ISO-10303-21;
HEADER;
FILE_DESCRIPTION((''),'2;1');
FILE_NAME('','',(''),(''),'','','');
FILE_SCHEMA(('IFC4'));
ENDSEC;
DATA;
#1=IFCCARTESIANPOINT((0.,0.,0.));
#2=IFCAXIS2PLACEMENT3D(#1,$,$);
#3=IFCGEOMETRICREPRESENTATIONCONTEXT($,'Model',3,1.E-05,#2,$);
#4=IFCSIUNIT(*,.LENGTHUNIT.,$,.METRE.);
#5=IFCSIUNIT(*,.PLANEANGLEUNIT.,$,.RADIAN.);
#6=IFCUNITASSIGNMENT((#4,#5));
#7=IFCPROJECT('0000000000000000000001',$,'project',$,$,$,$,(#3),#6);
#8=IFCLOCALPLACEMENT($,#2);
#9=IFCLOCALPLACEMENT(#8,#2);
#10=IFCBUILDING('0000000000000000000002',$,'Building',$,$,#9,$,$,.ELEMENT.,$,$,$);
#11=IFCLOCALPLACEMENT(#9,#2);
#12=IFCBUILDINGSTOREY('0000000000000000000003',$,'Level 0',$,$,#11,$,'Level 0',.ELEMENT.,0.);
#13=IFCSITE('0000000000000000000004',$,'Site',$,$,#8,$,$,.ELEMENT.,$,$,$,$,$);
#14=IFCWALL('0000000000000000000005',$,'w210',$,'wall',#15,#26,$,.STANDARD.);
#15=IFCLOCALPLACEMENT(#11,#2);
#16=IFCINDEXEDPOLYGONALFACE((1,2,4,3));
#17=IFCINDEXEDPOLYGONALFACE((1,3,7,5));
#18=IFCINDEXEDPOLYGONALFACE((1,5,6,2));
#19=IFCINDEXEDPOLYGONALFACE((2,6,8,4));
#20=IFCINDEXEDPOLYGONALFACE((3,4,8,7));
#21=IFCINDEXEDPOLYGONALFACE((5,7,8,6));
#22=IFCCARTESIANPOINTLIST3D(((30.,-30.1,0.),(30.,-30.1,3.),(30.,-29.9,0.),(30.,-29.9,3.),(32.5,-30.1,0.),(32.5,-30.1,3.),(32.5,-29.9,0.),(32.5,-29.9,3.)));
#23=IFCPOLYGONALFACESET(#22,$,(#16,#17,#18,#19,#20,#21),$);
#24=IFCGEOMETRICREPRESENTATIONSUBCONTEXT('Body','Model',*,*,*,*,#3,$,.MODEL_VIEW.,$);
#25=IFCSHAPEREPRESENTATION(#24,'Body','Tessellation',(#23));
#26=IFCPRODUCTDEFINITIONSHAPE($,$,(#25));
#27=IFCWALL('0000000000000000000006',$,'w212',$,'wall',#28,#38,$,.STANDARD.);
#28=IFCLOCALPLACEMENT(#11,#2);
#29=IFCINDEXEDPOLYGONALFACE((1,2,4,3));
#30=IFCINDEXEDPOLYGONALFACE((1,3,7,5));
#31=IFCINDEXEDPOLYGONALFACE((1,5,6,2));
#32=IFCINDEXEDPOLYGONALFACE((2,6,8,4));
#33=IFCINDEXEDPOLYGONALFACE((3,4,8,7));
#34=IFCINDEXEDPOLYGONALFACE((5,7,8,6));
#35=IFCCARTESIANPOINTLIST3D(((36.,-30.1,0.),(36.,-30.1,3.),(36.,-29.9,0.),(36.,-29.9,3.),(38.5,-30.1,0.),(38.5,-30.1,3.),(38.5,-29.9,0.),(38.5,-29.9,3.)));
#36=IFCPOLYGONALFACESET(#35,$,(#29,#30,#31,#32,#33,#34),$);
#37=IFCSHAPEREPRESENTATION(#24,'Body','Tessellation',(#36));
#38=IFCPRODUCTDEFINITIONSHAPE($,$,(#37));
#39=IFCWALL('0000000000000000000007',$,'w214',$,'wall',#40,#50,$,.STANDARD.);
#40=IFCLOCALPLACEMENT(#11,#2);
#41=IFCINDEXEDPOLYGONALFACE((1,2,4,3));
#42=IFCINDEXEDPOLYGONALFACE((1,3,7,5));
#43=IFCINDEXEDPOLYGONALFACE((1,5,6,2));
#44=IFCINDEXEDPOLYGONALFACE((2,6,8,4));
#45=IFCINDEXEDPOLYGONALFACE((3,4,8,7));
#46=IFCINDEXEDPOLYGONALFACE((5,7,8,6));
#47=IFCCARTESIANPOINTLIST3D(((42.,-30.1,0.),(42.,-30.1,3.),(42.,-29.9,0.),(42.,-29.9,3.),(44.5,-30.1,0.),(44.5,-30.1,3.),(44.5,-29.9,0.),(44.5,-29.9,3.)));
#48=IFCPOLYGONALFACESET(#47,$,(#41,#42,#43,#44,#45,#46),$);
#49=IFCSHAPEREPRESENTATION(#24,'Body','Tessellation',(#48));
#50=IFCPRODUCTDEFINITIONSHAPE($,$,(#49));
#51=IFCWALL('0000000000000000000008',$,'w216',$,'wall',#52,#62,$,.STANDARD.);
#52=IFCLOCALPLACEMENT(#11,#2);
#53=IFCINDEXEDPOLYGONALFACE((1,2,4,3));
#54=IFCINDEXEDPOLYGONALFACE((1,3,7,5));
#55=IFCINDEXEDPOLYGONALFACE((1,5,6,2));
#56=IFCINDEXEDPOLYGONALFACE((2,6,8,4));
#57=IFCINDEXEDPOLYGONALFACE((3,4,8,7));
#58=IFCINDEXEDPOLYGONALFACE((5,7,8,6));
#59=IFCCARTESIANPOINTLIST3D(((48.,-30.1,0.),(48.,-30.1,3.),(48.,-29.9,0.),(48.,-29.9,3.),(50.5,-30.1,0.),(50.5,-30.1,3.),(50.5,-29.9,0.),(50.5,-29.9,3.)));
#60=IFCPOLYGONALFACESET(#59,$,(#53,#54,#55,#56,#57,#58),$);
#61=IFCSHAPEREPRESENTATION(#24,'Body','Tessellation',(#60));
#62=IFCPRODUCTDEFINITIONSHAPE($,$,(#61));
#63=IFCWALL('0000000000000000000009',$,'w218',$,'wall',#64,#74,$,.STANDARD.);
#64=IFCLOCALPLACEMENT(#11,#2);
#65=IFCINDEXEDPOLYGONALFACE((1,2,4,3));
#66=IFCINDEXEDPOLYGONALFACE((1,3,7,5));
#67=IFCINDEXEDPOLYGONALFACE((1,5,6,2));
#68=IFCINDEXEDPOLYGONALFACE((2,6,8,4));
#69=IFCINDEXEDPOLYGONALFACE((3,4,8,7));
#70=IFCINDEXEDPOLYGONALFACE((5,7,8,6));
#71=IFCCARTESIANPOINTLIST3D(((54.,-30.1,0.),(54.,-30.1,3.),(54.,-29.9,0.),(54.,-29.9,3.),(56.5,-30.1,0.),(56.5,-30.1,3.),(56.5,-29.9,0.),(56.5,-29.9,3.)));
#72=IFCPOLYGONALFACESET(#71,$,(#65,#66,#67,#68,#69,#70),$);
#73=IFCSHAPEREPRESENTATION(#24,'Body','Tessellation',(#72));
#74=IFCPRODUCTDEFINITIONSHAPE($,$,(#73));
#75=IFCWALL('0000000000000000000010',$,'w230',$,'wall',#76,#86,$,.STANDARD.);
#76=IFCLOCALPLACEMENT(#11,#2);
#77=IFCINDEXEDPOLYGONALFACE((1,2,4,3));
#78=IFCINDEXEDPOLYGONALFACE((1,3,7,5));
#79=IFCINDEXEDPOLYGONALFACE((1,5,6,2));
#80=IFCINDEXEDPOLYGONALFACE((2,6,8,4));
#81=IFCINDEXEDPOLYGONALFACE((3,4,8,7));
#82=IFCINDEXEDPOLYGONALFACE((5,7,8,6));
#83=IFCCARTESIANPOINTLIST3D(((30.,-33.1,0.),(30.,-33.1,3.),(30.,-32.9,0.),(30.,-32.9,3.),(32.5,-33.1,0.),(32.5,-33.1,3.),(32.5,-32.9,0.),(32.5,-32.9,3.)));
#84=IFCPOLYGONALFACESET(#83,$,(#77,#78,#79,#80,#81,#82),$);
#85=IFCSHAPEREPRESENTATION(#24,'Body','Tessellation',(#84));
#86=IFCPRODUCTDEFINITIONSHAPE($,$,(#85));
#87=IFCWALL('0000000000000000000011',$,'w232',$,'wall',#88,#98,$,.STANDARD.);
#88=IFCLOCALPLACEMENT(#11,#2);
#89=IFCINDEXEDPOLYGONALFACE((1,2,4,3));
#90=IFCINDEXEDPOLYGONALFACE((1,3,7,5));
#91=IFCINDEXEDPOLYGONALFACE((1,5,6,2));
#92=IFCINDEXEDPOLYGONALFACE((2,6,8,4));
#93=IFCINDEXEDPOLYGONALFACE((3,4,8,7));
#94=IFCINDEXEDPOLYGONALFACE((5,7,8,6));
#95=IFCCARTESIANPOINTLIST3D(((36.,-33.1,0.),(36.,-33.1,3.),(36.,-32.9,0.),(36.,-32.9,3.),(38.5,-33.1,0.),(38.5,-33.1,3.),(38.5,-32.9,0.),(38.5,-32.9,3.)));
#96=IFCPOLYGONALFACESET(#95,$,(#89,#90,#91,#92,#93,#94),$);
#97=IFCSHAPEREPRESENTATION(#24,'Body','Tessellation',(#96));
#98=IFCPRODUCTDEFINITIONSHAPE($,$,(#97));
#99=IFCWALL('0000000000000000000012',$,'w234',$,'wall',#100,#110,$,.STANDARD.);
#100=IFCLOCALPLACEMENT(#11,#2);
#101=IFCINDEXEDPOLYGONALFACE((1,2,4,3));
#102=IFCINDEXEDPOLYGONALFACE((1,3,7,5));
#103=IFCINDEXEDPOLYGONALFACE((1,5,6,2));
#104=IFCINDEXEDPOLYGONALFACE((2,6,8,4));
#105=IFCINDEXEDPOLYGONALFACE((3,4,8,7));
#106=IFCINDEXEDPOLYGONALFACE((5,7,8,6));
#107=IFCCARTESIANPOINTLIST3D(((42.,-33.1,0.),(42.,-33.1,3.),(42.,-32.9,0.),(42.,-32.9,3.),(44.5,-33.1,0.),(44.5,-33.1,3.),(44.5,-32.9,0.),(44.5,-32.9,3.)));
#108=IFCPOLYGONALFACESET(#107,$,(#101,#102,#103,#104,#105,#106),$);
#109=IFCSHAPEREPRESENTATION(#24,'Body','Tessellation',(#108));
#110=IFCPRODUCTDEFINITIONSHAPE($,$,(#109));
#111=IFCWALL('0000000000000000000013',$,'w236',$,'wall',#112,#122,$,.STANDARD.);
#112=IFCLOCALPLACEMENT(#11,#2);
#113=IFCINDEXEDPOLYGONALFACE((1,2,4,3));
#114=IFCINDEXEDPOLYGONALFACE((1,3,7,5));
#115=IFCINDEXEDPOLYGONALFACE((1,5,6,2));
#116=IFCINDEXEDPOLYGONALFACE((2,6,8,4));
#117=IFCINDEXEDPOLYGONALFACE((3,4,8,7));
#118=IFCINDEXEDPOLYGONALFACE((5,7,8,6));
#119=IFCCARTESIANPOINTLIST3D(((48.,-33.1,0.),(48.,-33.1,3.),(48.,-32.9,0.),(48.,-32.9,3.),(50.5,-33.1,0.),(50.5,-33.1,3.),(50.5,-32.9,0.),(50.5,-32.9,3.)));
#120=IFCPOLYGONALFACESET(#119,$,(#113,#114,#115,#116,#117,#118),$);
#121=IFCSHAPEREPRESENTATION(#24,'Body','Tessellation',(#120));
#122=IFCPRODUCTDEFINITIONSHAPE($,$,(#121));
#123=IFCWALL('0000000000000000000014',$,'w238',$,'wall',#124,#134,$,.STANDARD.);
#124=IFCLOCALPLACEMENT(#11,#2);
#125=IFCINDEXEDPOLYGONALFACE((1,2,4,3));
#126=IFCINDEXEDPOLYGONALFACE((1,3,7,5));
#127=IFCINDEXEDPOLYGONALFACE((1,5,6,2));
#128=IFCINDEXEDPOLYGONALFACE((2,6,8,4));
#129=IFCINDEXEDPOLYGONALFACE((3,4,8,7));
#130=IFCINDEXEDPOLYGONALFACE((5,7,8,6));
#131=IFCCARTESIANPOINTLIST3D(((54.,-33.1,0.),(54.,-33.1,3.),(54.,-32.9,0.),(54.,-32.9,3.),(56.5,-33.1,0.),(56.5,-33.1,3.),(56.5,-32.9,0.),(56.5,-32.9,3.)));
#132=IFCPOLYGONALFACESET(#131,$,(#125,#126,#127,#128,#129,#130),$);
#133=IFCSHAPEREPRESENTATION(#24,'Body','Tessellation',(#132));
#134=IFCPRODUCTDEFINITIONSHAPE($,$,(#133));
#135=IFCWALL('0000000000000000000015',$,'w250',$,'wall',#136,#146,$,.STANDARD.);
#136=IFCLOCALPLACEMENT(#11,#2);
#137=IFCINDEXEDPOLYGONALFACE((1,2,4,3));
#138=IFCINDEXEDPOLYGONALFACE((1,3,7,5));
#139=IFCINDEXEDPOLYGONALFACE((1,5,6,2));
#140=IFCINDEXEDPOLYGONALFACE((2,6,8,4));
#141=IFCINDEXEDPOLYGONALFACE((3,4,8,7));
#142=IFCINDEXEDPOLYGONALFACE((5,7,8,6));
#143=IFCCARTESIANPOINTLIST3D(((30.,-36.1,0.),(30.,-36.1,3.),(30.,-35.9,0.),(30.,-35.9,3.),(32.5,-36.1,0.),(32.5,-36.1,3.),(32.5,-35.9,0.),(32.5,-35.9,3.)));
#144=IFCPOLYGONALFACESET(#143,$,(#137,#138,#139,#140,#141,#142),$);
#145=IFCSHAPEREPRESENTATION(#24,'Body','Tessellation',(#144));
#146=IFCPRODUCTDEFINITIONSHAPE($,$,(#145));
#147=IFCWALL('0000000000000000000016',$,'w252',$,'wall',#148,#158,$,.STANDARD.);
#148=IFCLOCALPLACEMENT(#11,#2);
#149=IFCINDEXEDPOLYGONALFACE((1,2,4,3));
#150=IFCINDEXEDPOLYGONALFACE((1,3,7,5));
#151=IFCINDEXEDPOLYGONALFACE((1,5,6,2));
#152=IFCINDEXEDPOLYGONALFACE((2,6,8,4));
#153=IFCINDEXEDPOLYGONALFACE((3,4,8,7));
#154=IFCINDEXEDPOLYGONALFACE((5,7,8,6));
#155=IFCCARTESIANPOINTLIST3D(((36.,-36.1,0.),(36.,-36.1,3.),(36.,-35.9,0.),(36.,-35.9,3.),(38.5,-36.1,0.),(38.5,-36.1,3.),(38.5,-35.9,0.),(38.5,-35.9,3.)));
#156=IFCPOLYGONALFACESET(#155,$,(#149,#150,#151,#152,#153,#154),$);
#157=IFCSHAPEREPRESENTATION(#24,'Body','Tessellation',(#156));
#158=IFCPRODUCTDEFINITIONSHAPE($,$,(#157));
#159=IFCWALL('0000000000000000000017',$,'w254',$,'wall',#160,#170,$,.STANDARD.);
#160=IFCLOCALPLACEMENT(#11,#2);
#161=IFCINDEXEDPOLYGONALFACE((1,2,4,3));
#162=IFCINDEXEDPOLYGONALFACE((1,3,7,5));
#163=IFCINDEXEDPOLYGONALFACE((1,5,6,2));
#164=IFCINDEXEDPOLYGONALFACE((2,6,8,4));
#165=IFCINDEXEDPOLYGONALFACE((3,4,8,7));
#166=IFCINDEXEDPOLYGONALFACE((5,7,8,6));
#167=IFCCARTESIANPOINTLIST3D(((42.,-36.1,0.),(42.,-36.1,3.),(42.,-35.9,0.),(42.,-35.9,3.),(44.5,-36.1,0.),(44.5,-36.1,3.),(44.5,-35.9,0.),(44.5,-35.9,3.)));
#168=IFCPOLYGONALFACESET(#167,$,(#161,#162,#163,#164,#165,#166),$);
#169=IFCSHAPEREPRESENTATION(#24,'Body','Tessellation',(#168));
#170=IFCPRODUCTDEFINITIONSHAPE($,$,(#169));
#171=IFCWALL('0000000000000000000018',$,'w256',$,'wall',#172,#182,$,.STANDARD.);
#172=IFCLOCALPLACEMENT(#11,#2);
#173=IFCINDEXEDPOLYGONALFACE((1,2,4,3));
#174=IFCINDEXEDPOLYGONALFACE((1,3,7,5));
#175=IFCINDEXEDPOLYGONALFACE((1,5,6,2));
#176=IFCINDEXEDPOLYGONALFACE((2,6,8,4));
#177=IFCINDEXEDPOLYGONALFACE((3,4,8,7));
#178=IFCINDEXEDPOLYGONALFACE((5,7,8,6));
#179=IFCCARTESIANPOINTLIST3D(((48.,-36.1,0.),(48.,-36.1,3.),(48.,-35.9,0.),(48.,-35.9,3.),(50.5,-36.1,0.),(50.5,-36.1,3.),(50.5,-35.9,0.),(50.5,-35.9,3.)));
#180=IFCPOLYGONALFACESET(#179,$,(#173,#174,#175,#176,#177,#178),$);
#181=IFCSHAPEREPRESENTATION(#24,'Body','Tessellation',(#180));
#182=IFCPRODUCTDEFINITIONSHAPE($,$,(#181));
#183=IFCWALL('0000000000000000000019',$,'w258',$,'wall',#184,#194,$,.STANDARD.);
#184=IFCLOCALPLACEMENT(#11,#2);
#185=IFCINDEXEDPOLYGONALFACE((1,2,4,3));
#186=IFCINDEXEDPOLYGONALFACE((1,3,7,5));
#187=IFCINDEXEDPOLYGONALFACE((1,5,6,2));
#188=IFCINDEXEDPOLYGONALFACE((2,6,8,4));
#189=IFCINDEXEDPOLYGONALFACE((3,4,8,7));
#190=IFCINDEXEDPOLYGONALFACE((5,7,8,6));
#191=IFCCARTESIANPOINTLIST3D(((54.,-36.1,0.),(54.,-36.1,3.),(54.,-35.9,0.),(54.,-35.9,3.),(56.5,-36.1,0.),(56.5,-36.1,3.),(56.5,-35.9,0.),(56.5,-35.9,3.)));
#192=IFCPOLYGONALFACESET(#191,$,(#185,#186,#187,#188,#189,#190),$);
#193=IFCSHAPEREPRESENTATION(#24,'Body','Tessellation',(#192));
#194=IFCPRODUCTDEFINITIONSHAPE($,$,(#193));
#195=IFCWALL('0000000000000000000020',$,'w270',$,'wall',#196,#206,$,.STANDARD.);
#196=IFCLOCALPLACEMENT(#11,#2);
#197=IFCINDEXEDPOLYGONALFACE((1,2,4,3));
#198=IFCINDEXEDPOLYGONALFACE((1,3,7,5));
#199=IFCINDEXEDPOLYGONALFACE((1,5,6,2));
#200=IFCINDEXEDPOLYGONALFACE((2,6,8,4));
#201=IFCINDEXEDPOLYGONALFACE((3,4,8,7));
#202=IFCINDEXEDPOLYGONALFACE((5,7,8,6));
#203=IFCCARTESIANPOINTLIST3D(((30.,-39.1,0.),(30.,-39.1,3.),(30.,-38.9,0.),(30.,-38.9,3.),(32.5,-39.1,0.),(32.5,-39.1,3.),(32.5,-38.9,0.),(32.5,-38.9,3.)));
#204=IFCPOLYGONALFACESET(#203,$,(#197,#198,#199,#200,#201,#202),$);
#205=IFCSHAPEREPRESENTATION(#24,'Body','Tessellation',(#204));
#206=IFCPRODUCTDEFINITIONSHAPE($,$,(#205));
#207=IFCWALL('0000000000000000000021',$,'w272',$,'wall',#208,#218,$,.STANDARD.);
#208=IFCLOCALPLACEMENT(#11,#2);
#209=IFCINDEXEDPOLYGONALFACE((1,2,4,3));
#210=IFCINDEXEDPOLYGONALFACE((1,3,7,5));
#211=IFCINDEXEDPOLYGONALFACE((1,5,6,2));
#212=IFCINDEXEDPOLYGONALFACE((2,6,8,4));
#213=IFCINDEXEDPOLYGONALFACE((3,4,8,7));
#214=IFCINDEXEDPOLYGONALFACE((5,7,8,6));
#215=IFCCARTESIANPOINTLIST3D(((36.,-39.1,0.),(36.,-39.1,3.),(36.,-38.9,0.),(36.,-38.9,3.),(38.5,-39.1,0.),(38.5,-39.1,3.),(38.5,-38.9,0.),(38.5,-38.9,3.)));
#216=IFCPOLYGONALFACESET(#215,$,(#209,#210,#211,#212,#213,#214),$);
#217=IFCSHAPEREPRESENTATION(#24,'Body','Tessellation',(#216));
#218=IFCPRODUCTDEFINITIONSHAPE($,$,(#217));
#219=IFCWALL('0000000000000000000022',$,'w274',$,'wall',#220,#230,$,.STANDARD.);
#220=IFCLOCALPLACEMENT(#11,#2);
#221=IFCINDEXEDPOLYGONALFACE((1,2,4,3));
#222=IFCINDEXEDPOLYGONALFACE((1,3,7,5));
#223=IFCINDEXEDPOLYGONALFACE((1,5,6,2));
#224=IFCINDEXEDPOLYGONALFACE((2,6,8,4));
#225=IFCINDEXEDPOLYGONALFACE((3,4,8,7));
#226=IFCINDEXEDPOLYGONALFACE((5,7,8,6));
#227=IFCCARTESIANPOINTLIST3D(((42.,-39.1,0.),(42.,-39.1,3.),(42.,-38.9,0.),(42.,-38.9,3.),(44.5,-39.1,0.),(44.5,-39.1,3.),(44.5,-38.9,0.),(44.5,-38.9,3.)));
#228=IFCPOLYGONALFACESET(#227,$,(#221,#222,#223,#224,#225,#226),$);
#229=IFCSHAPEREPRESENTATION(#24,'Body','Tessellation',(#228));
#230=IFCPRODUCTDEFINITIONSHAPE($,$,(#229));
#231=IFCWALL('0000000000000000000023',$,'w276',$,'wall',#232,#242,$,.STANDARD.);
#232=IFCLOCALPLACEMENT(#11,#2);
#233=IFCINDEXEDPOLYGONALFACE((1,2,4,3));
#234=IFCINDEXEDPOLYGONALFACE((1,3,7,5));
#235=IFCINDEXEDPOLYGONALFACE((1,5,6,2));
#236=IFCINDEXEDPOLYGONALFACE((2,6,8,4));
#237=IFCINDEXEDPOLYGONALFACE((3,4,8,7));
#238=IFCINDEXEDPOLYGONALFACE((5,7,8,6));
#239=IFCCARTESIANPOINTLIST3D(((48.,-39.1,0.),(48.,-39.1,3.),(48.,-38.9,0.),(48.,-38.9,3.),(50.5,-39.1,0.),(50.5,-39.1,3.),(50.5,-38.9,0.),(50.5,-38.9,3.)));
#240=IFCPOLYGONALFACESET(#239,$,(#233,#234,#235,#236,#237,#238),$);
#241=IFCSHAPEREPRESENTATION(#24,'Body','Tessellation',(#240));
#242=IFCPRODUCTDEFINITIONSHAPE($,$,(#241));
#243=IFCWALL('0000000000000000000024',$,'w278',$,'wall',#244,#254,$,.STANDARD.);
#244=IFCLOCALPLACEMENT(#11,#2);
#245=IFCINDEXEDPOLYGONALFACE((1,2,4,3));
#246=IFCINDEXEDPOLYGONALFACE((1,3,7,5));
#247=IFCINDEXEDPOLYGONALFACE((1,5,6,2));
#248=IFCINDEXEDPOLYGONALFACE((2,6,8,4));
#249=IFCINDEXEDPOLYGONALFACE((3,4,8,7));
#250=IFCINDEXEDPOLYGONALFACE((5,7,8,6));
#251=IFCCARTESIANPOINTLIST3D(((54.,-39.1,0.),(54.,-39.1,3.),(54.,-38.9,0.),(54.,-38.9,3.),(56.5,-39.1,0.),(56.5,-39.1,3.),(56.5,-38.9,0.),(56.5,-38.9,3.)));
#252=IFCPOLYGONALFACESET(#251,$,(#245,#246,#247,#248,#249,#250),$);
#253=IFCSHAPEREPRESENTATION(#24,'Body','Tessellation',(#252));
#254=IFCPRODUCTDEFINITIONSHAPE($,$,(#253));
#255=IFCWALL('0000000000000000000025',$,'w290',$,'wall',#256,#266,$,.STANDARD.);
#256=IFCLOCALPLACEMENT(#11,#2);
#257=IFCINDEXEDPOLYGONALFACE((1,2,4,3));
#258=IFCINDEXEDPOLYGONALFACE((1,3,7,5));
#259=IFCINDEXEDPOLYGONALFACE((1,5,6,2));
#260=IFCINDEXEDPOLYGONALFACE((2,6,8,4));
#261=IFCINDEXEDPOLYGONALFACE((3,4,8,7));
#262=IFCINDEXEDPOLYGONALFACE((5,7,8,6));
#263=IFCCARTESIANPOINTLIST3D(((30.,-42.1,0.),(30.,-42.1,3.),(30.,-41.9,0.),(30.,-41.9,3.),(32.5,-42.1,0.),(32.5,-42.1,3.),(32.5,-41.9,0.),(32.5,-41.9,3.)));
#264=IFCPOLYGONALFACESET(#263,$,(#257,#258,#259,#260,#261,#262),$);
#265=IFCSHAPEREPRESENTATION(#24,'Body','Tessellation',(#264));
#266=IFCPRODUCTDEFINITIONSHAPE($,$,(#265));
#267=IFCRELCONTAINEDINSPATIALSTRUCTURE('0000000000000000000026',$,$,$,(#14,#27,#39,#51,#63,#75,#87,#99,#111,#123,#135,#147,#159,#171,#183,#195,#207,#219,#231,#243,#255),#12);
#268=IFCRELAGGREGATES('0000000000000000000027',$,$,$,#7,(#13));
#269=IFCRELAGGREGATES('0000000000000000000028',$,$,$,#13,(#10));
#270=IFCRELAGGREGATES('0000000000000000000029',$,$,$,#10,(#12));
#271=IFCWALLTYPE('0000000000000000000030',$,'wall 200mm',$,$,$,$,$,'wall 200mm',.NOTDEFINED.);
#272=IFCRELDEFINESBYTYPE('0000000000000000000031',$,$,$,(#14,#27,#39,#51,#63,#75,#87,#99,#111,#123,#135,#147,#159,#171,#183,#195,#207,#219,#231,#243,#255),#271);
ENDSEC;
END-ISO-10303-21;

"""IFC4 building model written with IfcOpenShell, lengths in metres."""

from ifc_helpers import new_model, si_unit, frame, frame_2d, origin, place, context, subcontext, project, spatial, rectangle, extrude, type_object, element, save


model = new_model("IFC4")

# Units and contexts
model_context = context("Model", 3, precision=1e-05, world=origin())
body_context = subcontext(model_context, "Body", "Model", "MODEL_VIEW")
ifc_project = project(units=[si_unit("LENGTHUNIT", "METRE"), si_unit("PLANEANGLEUNIT", "RADIAN")], contexts=[model_context])

# Site, building, storey
site_placement = place(None, origin())
site = spatial("IfcSite", under=ifc_project, at=site_placement, Name="Site", CompositionType="ELEMENT")
building_placement = place(site_placement, origin())
building = spatial("IfcBuilding", under=site, at=building_placement, Name="Building", CompositionType="ELEMENT")
storey_placement = place(building_placement, origin())
storey = spatial("IfcBuildingStorey", under=building, at=storey_placement, Name="Level 0", LongName="Level 0", CompositionType="ELEMENT", Elevation=0.0)

# Walls
wall_type = type_object("IfcWallType", Name="wall 200mm", ElementType="wall 200mm", PredefinedType="NOTDEFINED")
for number, where, z_axis, x_axis, name in (
    (1, (30.0, -30.0, 0.0), (0.0, 0.0, 1.0), (1.0, 0.0, 0.0), "w210"),
    (2, (36.0, -30.0, 0.0), (0.0, 0.0, 1.0), (1.0, 0.0, 0.0), "w212"),
    (3, (42.0, -30.0, 0.0), (0.0, 0.0, 1.0), (1.0, 0.0, 0.0), "w214"),
    (4, (48.0, -30.0, 0.0), (0.0, 0.0, 1.0), (1.0, 0.0, 0.0), "w216"),
    (5, (54.0, -30.0, 0.0), (0.0, 0.0, 1.0), (1.0, 0.0, 0.0), "w218"),
    (6, (30.0, -33.0, 0.0), (0.0, 0.0, 1.0), (1.0, 0.0, 0.0), "w230"),
    (7, (36.0, -33.0, 0.0), (0.0, 0.0, 1.0), (1.0, 0.0, 0.0), "w232"),
    (8, (42.0, -33.0, 0.0), (0.0, 0.0, 1.0), (1.0, 0.0, 0.0), "w234"),
    (9, (48.0, -33.0, 0.0), (0.0, 0.0, 1.0), (1.0, 0.0, 0.0), "w236"),
    (10, (54.0, -33.0, 0.0), (0.0, 0.0, 1.0), (1.0, 0.0, 0.0), "w238"),
    (11, (30.0, -36.0, 0.0), (0.0, 0.0, 1.0), (1.0, 0.0, 0.0), "w250"),
    (12, (36.0, -36.0, 0.0), (0.0, 0.0, 1.0), (1.0, 0.0, 0.0), "w252"),
    (13, (42.0, -36.0, 0.0), (0.0, 0.0, 1.0), (1.0, 0.0, 0.0), "w254"),
    (14, (48.0, -36.0, 0.0), (0.0, 0.0, 1.0), (1.0, 0.0, 0.0), "w256"),
    (15, (54.0, -36.0, 0.0), (0.0, 0.0, 1.0), (1.0, 0.0, 0.0), "w258"),
    (16, (30.0, -39.0, 0.0), (0.0, 0.0, 1.0), (1.0, 0.0, 0.0), "w270"),
    (17, (36.0, -39.0, 0.0), (0.0, 0.0, 1.0), (1.0, 0.0, 0.0), "w272"),
    (18, (42.0, -39.0, 0.0), (0.0, 0.0, 1.0), (1.0, 0.0, 0.0), "w274"),
    (19, (48.0, -39.0, 0.0), (0.0, 0.0, 1.0), (1.0, 0.0, 0.0), "w276"),
    (20, (54.0, -39.0, 0.0), (0.0, 0.0, 1.0), (1.0, 0.0, 0.0), "w278"),
    (21, (30.0, -42.0, 0.0), (0.0, 0.0, 1.0), (1.0, 0.0, 0.0), "w290"),
):
    element("IfcWall", number, at=place(storey_placement, frame(where, z_axis=z_axis, x_axis=x_axis)), inside=storey, type_object=wall_type, Name=name, ObjectType="wall", PredefinedType="STANDARD", context=body_context, shape_type="SweptSolid", body=[
        extrude(rectangle(XDim=2.5, YDim=0.2, at=frame_2d((1.25, 0.0))), origin(), (0.0, 0.0, 1.0), 3.0),
    ])

save(model, "model.ifc")
